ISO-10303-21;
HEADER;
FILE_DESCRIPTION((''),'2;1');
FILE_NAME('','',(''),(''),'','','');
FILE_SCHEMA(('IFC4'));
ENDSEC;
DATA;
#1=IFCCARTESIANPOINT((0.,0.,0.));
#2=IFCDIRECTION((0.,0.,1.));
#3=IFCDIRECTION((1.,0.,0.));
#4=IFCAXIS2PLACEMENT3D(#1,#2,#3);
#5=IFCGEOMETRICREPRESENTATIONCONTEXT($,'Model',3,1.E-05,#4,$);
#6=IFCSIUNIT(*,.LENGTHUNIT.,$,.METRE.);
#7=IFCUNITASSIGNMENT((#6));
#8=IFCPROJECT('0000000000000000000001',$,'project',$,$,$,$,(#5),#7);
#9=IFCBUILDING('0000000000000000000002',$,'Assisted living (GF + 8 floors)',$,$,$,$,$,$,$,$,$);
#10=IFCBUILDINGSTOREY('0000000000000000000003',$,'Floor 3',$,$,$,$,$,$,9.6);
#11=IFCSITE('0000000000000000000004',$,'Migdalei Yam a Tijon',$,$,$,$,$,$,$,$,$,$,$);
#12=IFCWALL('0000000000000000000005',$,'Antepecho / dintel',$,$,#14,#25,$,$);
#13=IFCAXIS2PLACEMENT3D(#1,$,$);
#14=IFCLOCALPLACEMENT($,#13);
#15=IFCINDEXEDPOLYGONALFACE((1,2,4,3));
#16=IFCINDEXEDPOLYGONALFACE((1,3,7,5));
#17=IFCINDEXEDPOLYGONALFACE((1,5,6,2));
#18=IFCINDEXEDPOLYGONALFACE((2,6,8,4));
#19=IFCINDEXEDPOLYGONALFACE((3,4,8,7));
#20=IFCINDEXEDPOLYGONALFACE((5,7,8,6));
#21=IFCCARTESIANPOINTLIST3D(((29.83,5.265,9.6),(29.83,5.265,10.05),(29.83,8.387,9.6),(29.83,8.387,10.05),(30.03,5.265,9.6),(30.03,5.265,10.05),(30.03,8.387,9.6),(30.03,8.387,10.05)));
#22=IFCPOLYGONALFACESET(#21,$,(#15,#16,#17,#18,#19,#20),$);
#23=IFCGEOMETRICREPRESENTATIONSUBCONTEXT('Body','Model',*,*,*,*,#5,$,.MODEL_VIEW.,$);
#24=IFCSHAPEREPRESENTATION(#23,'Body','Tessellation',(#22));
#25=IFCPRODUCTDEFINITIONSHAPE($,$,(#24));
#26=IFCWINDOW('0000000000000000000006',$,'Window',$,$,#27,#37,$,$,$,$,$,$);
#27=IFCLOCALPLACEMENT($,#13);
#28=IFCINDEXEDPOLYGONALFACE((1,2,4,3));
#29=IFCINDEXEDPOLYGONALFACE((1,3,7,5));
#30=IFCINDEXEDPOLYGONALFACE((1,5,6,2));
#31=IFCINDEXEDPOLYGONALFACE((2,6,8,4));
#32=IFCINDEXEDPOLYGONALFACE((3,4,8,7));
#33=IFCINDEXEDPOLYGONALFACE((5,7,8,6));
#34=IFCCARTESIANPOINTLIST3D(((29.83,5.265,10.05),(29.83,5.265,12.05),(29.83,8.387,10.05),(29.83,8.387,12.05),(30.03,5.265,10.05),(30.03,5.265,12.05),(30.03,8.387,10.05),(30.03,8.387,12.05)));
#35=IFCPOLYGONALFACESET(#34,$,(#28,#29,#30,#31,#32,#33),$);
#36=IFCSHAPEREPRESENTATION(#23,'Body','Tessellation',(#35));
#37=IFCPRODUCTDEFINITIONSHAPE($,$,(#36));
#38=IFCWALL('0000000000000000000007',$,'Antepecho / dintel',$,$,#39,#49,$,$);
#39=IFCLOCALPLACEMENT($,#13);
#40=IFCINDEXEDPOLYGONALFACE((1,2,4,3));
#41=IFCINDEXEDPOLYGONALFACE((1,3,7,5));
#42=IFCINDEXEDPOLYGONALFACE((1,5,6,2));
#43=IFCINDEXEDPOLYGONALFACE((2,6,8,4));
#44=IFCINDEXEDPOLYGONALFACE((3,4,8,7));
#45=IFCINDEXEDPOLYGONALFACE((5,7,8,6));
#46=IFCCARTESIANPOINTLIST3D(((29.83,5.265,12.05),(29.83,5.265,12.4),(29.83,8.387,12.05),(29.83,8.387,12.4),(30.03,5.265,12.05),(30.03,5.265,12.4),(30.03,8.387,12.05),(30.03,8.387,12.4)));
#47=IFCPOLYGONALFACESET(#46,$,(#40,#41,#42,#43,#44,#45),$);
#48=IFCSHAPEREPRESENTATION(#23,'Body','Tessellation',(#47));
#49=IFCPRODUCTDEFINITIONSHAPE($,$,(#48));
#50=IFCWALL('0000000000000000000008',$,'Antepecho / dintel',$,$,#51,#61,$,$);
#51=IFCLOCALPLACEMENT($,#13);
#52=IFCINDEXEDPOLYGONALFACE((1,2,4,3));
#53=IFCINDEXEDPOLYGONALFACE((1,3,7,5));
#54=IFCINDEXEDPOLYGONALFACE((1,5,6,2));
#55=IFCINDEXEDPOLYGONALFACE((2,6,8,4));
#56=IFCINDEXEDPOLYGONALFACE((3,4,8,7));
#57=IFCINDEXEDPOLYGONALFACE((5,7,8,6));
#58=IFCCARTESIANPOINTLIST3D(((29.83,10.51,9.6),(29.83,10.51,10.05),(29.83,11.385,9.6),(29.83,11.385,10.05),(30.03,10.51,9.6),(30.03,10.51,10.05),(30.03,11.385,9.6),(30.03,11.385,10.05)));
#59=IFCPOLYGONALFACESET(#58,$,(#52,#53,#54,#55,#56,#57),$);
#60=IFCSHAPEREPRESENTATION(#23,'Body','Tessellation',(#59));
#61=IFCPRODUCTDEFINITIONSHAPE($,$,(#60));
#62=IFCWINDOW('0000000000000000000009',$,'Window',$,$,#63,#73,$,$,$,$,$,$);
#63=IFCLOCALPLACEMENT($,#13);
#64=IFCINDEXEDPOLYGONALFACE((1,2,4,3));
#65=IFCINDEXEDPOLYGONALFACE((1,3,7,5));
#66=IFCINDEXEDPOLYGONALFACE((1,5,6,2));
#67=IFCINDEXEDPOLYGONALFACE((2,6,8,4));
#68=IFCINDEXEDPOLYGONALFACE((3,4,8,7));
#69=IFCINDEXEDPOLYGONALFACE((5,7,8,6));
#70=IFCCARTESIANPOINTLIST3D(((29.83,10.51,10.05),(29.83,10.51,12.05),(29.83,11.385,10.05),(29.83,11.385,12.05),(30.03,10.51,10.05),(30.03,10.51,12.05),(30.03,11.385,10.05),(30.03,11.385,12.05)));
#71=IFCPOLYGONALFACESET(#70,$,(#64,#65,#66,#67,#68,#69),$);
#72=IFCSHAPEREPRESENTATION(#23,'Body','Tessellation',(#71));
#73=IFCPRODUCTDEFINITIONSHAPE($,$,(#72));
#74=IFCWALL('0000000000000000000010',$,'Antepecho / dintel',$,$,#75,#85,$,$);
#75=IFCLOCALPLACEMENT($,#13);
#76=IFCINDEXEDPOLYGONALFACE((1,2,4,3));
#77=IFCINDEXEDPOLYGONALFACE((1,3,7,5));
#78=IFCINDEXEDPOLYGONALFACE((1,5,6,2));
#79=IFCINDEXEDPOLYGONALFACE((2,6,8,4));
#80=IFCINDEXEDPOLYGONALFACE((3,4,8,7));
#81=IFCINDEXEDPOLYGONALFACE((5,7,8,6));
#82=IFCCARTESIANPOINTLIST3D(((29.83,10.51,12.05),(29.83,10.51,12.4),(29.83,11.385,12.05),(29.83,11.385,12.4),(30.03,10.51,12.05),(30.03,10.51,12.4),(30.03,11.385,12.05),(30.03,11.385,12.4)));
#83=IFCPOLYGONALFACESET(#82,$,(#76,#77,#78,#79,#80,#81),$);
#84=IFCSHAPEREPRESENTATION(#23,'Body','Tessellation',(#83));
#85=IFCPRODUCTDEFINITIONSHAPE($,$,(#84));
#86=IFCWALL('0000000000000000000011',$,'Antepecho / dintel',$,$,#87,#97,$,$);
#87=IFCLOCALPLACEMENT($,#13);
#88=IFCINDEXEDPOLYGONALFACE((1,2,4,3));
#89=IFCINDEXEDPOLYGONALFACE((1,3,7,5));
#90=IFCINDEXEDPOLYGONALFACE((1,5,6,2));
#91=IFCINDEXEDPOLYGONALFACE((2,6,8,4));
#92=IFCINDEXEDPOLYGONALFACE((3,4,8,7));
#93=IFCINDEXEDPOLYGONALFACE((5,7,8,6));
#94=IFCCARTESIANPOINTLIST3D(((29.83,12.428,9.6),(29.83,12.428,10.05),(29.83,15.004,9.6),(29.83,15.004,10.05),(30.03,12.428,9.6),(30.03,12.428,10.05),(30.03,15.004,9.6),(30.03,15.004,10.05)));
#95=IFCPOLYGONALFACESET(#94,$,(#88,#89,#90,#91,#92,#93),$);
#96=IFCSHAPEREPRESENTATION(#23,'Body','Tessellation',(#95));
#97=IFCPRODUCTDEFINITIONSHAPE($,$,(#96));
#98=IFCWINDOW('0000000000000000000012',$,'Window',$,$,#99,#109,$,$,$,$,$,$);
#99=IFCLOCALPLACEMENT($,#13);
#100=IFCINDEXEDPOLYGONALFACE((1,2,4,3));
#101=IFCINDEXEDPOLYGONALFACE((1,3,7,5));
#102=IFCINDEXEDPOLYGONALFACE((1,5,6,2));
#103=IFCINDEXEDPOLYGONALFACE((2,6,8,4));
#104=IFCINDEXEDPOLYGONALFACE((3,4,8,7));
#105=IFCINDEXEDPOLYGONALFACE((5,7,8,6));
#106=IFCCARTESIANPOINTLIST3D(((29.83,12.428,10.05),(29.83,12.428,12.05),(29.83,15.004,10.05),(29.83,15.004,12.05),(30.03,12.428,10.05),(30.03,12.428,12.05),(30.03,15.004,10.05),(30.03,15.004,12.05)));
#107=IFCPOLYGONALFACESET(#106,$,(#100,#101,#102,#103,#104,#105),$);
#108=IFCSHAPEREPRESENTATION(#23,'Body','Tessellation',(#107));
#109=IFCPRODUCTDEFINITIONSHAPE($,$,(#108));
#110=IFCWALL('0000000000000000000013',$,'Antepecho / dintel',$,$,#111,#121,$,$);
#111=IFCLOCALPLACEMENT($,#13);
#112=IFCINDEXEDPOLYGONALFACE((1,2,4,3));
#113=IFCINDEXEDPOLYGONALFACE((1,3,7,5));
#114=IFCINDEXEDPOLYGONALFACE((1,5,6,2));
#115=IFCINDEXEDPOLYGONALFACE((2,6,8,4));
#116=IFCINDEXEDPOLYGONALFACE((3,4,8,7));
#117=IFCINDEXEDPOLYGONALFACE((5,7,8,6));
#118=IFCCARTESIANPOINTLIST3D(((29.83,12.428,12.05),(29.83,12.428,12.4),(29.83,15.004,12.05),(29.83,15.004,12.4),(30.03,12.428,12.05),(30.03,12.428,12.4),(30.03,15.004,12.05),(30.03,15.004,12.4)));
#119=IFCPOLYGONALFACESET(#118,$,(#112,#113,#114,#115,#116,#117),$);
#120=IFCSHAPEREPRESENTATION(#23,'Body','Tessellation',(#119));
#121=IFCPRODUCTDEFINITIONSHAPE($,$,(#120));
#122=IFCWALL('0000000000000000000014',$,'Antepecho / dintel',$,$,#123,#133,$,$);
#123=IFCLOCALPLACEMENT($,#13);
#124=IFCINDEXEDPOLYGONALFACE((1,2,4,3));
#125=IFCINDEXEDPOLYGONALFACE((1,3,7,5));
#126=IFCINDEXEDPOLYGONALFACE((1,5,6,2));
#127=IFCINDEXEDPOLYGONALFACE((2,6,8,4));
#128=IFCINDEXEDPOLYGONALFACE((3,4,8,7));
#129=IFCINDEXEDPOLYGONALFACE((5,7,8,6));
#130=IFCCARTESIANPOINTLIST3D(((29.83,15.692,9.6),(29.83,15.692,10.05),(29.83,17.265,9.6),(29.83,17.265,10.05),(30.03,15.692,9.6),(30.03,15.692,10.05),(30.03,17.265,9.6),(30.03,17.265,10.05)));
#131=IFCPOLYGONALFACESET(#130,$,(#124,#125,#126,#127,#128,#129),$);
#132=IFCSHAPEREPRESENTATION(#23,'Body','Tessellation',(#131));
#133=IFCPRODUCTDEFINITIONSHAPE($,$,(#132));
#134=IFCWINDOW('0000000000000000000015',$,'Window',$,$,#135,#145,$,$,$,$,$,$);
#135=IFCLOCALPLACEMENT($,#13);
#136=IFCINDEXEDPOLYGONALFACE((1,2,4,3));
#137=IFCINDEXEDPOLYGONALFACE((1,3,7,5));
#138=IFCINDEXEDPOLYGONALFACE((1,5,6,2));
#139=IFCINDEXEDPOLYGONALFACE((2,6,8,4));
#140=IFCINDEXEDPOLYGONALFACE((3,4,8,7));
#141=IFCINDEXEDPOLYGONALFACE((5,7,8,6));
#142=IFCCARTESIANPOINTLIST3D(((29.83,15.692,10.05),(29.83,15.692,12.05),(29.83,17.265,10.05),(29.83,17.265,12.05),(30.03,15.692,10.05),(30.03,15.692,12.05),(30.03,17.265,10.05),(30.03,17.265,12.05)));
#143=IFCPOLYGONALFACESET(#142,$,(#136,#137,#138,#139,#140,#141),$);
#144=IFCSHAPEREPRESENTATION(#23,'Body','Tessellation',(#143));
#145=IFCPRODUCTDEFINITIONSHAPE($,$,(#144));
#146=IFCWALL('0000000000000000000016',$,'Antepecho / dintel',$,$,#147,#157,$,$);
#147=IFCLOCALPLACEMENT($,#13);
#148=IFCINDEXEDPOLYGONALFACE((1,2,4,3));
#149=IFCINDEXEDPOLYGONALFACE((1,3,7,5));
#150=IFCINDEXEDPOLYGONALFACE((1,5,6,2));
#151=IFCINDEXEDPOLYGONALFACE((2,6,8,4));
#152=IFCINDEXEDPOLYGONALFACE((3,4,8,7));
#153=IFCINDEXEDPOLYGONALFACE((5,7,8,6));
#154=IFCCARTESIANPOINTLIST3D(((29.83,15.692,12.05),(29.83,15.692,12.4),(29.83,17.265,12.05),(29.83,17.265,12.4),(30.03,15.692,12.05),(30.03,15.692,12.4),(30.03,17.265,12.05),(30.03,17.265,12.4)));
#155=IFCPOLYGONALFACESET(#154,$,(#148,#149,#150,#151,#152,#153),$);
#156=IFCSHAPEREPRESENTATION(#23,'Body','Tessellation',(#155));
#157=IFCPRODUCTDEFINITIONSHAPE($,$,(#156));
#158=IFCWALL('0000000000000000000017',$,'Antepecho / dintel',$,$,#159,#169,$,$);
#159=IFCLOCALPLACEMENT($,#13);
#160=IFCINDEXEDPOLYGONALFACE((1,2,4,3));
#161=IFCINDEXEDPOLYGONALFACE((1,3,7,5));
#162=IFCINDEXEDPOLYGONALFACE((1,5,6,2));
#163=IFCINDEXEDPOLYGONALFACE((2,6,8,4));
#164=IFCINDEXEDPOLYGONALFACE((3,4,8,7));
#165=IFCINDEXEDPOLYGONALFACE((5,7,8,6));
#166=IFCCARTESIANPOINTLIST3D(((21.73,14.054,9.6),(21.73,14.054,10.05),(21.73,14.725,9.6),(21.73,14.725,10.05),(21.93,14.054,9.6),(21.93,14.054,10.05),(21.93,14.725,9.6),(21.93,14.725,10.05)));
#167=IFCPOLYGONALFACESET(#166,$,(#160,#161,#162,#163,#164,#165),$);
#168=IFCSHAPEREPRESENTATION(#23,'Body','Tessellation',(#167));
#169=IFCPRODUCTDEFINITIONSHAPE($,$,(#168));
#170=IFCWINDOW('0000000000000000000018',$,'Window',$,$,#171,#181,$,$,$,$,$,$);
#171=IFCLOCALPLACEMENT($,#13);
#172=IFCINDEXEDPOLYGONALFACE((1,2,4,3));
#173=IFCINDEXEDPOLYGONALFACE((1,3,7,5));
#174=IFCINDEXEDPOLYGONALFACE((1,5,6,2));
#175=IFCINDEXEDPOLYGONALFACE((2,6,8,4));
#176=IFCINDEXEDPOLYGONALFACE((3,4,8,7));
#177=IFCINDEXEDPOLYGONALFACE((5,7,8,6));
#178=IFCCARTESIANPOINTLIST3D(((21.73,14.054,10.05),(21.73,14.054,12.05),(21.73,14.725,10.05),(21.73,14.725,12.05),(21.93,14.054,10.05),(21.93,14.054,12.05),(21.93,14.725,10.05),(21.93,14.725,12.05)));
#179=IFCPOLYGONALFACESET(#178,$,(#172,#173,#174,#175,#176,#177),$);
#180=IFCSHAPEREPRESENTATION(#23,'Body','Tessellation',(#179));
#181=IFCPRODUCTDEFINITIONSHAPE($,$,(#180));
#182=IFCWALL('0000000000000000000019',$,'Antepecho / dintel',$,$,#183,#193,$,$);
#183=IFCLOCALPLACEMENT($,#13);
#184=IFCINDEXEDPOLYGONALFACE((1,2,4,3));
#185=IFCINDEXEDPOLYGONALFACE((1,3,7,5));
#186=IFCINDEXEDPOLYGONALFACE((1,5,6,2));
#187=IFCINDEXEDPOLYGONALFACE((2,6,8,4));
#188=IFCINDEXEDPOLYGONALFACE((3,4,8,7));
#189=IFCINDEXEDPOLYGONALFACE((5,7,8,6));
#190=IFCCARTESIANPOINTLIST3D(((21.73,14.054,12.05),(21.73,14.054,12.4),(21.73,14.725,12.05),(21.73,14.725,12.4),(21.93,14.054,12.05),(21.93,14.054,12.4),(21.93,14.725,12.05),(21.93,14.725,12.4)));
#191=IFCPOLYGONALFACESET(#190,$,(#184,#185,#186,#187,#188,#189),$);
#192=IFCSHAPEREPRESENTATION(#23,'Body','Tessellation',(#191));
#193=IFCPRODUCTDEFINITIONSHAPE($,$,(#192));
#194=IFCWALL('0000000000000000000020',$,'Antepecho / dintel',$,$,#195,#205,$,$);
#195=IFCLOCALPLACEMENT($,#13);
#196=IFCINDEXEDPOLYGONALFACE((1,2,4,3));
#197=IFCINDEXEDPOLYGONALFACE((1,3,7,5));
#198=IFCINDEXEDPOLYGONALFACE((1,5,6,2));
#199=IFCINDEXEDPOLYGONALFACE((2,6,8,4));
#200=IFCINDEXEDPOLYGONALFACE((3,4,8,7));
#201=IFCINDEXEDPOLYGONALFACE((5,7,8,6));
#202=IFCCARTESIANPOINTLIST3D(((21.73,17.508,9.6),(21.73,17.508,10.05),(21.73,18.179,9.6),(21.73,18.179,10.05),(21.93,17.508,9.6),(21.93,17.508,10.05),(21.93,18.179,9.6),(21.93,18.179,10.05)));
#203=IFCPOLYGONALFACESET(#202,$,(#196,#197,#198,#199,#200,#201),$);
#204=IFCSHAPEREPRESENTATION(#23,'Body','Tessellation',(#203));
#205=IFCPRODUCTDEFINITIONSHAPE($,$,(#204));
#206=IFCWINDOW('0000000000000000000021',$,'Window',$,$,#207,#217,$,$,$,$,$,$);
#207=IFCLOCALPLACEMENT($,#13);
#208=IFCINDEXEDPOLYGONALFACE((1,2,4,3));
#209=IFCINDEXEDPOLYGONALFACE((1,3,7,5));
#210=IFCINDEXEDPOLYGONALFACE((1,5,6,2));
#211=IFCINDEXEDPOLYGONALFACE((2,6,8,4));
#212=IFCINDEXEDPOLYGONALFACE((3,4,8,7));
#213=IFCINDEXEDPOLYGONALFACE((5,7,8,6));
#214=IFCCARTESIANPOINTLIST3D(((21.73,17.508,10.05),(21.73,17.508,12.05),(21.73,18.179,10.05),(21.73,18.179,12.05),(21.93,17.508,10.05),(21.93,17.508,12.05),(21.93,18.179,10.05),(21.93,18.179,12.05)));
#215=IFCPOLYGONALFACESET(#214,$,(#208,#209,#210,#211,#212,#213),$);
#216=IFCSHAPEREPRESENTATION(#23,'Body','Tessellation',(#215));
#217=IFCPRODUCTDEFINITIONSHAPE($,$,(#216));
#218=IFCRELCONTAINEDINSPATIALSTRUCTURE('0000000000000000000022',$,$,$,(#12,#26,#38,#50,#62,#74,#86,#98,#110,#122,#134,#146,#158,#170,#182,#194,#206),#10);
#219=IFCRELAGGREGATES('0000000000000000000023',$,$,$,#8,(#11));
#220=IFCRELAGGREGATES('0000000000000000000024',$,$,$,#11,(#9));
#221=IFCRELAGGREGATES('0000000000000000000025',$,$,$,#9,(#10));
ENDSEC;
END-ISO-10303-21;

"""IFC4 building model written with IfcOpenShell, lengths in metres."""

from ifc_helpers import new_model, si_unit, frame, origin_with_axes, context, subcontext, project, spatial, line, indexed_curve, outline, extrude, element, save


model = new_model("IFC4")

# Units and contexts
model_context = context("Model", 3, precision=1e-05, world=origin_with_axes())
body_context = subcontext(model_context, "Body", "Model", "MODEL_VIEW")
ifc_project = project(units=[si_unit("LENGTHUNIT", "METRE")], contexts=[model_context])

# Site, building, storey
site = spatial("IfcSite", under=ifc_project, Name="Migdalei Yam a Tijon")
building = spatial("IfcBuilding", under=site, Name="Assisted living (GF + 8 floors)")
storey = spatial("IfcBuildingStorey", under=building, Name="Floor 3", Elevation=9.6)

# Wall
element("IfcWall", 1, inside=storey, Name="Antepecho / dintel", context=body_context, shape_type="SweptSolid", body=[
    extrude(outline(indexed_curve([(0.0, 0.0), (0.2, 0.0), (0.2, 3.122), (0.0, 3.122)], segments=[line(1, 2, 3, 4, 1)])), frame((29.83, 5.265, 9.6), z_axis=(0.0, 0.0, 1.0), x_axis=(1.0, 0.0, 0.0)), (0.0, 0.0, 1.0), 0.45),
])

# Window
element("IfcWindow", 2, inside=storey, Name="Window", context=body_context, shape_type="SweptSolid", body=[
    extrude(outline(indexed_curve([(0.0, 0.0), (0.2, 0.0), (0.2, 3.122), (0.0, 3.122)], segments=[line(1, 2, 3, 4, 1)])), frame((29.83, 5.265, 10.05), z_axis=(0.0, 0.0, 1.0), x_axis=(1.0, 0.0, 0.0)), (0.0, 0.0, 1.0), 2.0),
])

# Walls
element("IfcWall", 3, inside=storey, Name="Antepecho / dintel", context=body_context, shape_type="SweptSolid", body=[
    extrude(outline(indexed_curve([(0.0, 0.0), (0.2, 0.0), (0.2, 3.122), (0.0, 3.122)], segments=[line(1, 2, 3, 4, 1)])), frame((29.83, 5.265, 12.05), z_axis=(0.0, 0.0, 1.0), x_axis=(1.0, 0.0, 0.0)), (0.0, 0.0, 1.0), 0.35),
])
element("IfcWall", 4, inside=storey, Name="Antepecho / dintel", context=body_context, shape_type="SweptSolid", body=[
    extrude(outline(indexed_curve([(0.0, 0.0), (0.2, 0.0), (0.2, 0.875), (0.0, 0.875)], segments=[line(1, 2, 3, 4, 1)])), frame((29.83, 10.51, 9.6), z_axis=(0.0, 0.0, 1.0), x_axis=(1.0, 0.0, 0.0)), (0.0, 0.0, 1.0), 0.45),
])

# Window
element("IfcWindow", 5, inside=storey, Name="Window", context=body_context, shape_type="SweptSolid", body=[
    extrude(outline(indexed_curve([(0.0, 0.0), (0.2, 0.0), (0.2, 0.875), (0.0, 0.875)], segments=[line(1, 2, 3, 4, 1)])), frame((29.83, 10.51, 10.05), z_axis=(0.0, 0.0, 1.0), x_axis=(1.0, 0.0, 0.0)), (0.0, 0.0, 1.0), 2.0),
])

# Walls
element("IfcWall", 6, inside=storey, Name="Antepecho / dintel", context=body_context, shape_type="SweptSolid", body=[
    extrude(outline(indexed_curve([(0.0, 0.0), (0.2, 0.0), (0.2, 0.875), (0.0, 0.875)], segments=[line(1, 2, 3, 4, 1)])), frame((29.83, 10.51, 12.05), z_axis=(0.0, 0.0, 1.0), x_axis=(1.0, 0.0, 0.0)), (0.0, 0.0, 1.0), 0.35),
])
element("IfcWall", 7, inside=storey, Name="Antepecho / dintel", context=body_context, shape_type="SweptSolid", body=[
    extrude(outline(indexed_curve([(0.0, 0.0), (0.2, 0.0), (0.2, 2.576), (0.0, 2.576)], segments=[line(1, 2, 3, 4, 1)])), frame((29.83, 12.428, 9.6), z_axis=(0.0, 0.0, 1.0), x_axis=(1.0, 0.0, 0.0)), (0.0, 0.0, 1.0), 0.45),
])

# Window
element("IfcWindow", 8, inside=storey, Name="Window", context=body_context, shape_type="SweptSolid", body=[
    extrude(outline(indexed_curve([(0.0, 0.0), (0.2, 0.0), (0.2, 2.576), (0.0, 2.576)], segments=[line(1, 2, 3, 4, 1)])), frame((29.83, 12.428, 10.05), z_axis=(0.0, 0.0, 1.0), x_axis=(1.0, 0.0, 0.0)), (0.0, 0.0, 1.0), 2.0),
])

# Walls
element("IfcWall", 9, inside=storey, Name="Antepecho / dintel", context=body_context, shape_type="SweptSolid", body=[
    extrude(outline(indexed_curve([(0.0, 0.0), (0.2, 0.0), (0.2, 2.576), (0.0, 2.576)], segments=[line(1, 2, 3, 4, 1)])), frame((29.83, 12.428, 12.05), z_axis=(0.0, 0.0, 1.0), x_axis=(1.0, 0.0, 0.0)), (0.0, 0.0, 1.0), 0.35),
])
element("IfcWall", 10, inside=storey, Name="Antepecho / dintel", context=body_context, shape_type="SweptSolid", body=[
    extrude(outline(indexed_curve([(0.0, 0.0), (0.2, 0.0), (0.2, 1.573), (0.0, 1.573)], segments=[line(1, 2, 3, 4, 1)])), frame((29.83, 15.692, 9.6), z_axis=(0.0, 0.0, 1.0), x_axis=(1.0, 0.0, 0.0)), (0.0, 0.0, 1.0), 0.45),
])

# Window
element("IfcWindow", 11, inside=storey, Name="Window", context=body_context, shape_type="SweptSolid", body=[
    extrude(outline(indexed_curve([(0.0, 0.0), (0.2, 0.0), (0.2, 1.573), (0.0, 1.573)], segments=[line(1, 2, 3, 4, 1)])), frame((29.83, 15.692, 10.05), z_axis=(0.0, 0.0, 1.0), x_axis=(1.0, 0.0, 0.0)), (0.0, 0.0, 1.0), 2.0),
])

# Walls
element("IfcWall", 12, inside=storey, Name="Antepecho / dintel", context=body_context, shape_type="SweptSolid", body=[
    extrude(outline(indexed_curve([(0.0, 0.0), (0.2, 0.0), (0.2, 1.573), (0.0, 1.573)], segments=[line(1, 2, 3, 4, 1)])), frame((29.83, 15.692, 12.05), z_axis=(0.0, 0.0, 1.0), x_axis=(1.0, 0.0, 0.0)), (0.0, 0.0, 1.0), 0.35),
])
element("IfcWall", 13, inside=storey, Name="Antepecho / dintel", context=body_context, shape_type="SweptSolid", body=[
    extrude(outline(indexed_curve([(0.0, 0.0), (0.2, 0.0), (0.2, 0.671), (0.0, 0.671)], segments=[line(1, 2, 3, 4, 1)])), frame((21.73, 14.054, 9.6), z_axis=(0.0, 0.0, 1.0), x_axis=(1.0, 0.0, 0.0)), (0.0, 0.0, 1.0), 0.45),
])

# Window
element("IfcWindow", 14, inside=storey, Name="Window", context=body_context, shape_type="SweptSolid", body=[
    extrude(outline(indexed_curve([(0.0, 0.0), (0.2, 0.0), (0.2, 0.671), (0.0, 0.671)], segments=[line(1, 2, 3, 4, 1)])), frame((21.73, 14.054, 10.05), z_axis=(0.0, 0.0, 1.0), x_axis=(1.0, 0.0, 0.0)), (0.0, 0.0, 1.0), 2.0),
])

# Walls
element("IfcWall", 15, inside=storey, Name="Antepecho / dintel", context=body_context, shape_type="SweptSolid", body=[
    extrude(outline(indexed_curve([(0.0, 0.0), (0.2, 0.0), (0.2, 0.671), (0.0, 0.671)], segments=[line(1, 2, 3, 4, 1)])), frame((21.73, 14.054, 12.05), z_axis=(0.0, 0.0, 1.0), x_axis=(1.0, 0.0, 0.0)), (0.0, 0.0, 1.0), 0.35),
])
element("IfcWall", 16, inside=storey, Name="Antepecho / dintel", context=body_context, shape_type="SweptSolid", body=[
    extrude(outline(indexed_curve([(0.0, 0.0), (0.2, 0.0), (0.2, 0.671), (0.0, 0.671)], segments=[line(1, 2, 3, 4, 1)])), frame((21.73, 17.508, 9.6), z_axis=(0.0, 0.0, 1.0), x_axis=(1.0, 0.0, 0.0)), (0.0, 0.0, 1.0), 0.45),
])

# Window
element("IfcWindow", 17, inside=storey, Name="Window", context=body_context, shape_type="SweptSolid", body=[
    extrude(outline(indexed_curve([(0.0, 0.0), (0.2, 0.0), (0.2, 0.671), (0.0, 0.671)], segments=[line(1, 2, 3, 4, 1)])), frame((21.73, 17.508, 10.05), z_axis=(0.0, 0.0, 1.0), x_axis=(1.0, 0.0, 0.0)), (0.0, 0.0, 1.0), 2.0),
])

save(model, "model.ifc")
